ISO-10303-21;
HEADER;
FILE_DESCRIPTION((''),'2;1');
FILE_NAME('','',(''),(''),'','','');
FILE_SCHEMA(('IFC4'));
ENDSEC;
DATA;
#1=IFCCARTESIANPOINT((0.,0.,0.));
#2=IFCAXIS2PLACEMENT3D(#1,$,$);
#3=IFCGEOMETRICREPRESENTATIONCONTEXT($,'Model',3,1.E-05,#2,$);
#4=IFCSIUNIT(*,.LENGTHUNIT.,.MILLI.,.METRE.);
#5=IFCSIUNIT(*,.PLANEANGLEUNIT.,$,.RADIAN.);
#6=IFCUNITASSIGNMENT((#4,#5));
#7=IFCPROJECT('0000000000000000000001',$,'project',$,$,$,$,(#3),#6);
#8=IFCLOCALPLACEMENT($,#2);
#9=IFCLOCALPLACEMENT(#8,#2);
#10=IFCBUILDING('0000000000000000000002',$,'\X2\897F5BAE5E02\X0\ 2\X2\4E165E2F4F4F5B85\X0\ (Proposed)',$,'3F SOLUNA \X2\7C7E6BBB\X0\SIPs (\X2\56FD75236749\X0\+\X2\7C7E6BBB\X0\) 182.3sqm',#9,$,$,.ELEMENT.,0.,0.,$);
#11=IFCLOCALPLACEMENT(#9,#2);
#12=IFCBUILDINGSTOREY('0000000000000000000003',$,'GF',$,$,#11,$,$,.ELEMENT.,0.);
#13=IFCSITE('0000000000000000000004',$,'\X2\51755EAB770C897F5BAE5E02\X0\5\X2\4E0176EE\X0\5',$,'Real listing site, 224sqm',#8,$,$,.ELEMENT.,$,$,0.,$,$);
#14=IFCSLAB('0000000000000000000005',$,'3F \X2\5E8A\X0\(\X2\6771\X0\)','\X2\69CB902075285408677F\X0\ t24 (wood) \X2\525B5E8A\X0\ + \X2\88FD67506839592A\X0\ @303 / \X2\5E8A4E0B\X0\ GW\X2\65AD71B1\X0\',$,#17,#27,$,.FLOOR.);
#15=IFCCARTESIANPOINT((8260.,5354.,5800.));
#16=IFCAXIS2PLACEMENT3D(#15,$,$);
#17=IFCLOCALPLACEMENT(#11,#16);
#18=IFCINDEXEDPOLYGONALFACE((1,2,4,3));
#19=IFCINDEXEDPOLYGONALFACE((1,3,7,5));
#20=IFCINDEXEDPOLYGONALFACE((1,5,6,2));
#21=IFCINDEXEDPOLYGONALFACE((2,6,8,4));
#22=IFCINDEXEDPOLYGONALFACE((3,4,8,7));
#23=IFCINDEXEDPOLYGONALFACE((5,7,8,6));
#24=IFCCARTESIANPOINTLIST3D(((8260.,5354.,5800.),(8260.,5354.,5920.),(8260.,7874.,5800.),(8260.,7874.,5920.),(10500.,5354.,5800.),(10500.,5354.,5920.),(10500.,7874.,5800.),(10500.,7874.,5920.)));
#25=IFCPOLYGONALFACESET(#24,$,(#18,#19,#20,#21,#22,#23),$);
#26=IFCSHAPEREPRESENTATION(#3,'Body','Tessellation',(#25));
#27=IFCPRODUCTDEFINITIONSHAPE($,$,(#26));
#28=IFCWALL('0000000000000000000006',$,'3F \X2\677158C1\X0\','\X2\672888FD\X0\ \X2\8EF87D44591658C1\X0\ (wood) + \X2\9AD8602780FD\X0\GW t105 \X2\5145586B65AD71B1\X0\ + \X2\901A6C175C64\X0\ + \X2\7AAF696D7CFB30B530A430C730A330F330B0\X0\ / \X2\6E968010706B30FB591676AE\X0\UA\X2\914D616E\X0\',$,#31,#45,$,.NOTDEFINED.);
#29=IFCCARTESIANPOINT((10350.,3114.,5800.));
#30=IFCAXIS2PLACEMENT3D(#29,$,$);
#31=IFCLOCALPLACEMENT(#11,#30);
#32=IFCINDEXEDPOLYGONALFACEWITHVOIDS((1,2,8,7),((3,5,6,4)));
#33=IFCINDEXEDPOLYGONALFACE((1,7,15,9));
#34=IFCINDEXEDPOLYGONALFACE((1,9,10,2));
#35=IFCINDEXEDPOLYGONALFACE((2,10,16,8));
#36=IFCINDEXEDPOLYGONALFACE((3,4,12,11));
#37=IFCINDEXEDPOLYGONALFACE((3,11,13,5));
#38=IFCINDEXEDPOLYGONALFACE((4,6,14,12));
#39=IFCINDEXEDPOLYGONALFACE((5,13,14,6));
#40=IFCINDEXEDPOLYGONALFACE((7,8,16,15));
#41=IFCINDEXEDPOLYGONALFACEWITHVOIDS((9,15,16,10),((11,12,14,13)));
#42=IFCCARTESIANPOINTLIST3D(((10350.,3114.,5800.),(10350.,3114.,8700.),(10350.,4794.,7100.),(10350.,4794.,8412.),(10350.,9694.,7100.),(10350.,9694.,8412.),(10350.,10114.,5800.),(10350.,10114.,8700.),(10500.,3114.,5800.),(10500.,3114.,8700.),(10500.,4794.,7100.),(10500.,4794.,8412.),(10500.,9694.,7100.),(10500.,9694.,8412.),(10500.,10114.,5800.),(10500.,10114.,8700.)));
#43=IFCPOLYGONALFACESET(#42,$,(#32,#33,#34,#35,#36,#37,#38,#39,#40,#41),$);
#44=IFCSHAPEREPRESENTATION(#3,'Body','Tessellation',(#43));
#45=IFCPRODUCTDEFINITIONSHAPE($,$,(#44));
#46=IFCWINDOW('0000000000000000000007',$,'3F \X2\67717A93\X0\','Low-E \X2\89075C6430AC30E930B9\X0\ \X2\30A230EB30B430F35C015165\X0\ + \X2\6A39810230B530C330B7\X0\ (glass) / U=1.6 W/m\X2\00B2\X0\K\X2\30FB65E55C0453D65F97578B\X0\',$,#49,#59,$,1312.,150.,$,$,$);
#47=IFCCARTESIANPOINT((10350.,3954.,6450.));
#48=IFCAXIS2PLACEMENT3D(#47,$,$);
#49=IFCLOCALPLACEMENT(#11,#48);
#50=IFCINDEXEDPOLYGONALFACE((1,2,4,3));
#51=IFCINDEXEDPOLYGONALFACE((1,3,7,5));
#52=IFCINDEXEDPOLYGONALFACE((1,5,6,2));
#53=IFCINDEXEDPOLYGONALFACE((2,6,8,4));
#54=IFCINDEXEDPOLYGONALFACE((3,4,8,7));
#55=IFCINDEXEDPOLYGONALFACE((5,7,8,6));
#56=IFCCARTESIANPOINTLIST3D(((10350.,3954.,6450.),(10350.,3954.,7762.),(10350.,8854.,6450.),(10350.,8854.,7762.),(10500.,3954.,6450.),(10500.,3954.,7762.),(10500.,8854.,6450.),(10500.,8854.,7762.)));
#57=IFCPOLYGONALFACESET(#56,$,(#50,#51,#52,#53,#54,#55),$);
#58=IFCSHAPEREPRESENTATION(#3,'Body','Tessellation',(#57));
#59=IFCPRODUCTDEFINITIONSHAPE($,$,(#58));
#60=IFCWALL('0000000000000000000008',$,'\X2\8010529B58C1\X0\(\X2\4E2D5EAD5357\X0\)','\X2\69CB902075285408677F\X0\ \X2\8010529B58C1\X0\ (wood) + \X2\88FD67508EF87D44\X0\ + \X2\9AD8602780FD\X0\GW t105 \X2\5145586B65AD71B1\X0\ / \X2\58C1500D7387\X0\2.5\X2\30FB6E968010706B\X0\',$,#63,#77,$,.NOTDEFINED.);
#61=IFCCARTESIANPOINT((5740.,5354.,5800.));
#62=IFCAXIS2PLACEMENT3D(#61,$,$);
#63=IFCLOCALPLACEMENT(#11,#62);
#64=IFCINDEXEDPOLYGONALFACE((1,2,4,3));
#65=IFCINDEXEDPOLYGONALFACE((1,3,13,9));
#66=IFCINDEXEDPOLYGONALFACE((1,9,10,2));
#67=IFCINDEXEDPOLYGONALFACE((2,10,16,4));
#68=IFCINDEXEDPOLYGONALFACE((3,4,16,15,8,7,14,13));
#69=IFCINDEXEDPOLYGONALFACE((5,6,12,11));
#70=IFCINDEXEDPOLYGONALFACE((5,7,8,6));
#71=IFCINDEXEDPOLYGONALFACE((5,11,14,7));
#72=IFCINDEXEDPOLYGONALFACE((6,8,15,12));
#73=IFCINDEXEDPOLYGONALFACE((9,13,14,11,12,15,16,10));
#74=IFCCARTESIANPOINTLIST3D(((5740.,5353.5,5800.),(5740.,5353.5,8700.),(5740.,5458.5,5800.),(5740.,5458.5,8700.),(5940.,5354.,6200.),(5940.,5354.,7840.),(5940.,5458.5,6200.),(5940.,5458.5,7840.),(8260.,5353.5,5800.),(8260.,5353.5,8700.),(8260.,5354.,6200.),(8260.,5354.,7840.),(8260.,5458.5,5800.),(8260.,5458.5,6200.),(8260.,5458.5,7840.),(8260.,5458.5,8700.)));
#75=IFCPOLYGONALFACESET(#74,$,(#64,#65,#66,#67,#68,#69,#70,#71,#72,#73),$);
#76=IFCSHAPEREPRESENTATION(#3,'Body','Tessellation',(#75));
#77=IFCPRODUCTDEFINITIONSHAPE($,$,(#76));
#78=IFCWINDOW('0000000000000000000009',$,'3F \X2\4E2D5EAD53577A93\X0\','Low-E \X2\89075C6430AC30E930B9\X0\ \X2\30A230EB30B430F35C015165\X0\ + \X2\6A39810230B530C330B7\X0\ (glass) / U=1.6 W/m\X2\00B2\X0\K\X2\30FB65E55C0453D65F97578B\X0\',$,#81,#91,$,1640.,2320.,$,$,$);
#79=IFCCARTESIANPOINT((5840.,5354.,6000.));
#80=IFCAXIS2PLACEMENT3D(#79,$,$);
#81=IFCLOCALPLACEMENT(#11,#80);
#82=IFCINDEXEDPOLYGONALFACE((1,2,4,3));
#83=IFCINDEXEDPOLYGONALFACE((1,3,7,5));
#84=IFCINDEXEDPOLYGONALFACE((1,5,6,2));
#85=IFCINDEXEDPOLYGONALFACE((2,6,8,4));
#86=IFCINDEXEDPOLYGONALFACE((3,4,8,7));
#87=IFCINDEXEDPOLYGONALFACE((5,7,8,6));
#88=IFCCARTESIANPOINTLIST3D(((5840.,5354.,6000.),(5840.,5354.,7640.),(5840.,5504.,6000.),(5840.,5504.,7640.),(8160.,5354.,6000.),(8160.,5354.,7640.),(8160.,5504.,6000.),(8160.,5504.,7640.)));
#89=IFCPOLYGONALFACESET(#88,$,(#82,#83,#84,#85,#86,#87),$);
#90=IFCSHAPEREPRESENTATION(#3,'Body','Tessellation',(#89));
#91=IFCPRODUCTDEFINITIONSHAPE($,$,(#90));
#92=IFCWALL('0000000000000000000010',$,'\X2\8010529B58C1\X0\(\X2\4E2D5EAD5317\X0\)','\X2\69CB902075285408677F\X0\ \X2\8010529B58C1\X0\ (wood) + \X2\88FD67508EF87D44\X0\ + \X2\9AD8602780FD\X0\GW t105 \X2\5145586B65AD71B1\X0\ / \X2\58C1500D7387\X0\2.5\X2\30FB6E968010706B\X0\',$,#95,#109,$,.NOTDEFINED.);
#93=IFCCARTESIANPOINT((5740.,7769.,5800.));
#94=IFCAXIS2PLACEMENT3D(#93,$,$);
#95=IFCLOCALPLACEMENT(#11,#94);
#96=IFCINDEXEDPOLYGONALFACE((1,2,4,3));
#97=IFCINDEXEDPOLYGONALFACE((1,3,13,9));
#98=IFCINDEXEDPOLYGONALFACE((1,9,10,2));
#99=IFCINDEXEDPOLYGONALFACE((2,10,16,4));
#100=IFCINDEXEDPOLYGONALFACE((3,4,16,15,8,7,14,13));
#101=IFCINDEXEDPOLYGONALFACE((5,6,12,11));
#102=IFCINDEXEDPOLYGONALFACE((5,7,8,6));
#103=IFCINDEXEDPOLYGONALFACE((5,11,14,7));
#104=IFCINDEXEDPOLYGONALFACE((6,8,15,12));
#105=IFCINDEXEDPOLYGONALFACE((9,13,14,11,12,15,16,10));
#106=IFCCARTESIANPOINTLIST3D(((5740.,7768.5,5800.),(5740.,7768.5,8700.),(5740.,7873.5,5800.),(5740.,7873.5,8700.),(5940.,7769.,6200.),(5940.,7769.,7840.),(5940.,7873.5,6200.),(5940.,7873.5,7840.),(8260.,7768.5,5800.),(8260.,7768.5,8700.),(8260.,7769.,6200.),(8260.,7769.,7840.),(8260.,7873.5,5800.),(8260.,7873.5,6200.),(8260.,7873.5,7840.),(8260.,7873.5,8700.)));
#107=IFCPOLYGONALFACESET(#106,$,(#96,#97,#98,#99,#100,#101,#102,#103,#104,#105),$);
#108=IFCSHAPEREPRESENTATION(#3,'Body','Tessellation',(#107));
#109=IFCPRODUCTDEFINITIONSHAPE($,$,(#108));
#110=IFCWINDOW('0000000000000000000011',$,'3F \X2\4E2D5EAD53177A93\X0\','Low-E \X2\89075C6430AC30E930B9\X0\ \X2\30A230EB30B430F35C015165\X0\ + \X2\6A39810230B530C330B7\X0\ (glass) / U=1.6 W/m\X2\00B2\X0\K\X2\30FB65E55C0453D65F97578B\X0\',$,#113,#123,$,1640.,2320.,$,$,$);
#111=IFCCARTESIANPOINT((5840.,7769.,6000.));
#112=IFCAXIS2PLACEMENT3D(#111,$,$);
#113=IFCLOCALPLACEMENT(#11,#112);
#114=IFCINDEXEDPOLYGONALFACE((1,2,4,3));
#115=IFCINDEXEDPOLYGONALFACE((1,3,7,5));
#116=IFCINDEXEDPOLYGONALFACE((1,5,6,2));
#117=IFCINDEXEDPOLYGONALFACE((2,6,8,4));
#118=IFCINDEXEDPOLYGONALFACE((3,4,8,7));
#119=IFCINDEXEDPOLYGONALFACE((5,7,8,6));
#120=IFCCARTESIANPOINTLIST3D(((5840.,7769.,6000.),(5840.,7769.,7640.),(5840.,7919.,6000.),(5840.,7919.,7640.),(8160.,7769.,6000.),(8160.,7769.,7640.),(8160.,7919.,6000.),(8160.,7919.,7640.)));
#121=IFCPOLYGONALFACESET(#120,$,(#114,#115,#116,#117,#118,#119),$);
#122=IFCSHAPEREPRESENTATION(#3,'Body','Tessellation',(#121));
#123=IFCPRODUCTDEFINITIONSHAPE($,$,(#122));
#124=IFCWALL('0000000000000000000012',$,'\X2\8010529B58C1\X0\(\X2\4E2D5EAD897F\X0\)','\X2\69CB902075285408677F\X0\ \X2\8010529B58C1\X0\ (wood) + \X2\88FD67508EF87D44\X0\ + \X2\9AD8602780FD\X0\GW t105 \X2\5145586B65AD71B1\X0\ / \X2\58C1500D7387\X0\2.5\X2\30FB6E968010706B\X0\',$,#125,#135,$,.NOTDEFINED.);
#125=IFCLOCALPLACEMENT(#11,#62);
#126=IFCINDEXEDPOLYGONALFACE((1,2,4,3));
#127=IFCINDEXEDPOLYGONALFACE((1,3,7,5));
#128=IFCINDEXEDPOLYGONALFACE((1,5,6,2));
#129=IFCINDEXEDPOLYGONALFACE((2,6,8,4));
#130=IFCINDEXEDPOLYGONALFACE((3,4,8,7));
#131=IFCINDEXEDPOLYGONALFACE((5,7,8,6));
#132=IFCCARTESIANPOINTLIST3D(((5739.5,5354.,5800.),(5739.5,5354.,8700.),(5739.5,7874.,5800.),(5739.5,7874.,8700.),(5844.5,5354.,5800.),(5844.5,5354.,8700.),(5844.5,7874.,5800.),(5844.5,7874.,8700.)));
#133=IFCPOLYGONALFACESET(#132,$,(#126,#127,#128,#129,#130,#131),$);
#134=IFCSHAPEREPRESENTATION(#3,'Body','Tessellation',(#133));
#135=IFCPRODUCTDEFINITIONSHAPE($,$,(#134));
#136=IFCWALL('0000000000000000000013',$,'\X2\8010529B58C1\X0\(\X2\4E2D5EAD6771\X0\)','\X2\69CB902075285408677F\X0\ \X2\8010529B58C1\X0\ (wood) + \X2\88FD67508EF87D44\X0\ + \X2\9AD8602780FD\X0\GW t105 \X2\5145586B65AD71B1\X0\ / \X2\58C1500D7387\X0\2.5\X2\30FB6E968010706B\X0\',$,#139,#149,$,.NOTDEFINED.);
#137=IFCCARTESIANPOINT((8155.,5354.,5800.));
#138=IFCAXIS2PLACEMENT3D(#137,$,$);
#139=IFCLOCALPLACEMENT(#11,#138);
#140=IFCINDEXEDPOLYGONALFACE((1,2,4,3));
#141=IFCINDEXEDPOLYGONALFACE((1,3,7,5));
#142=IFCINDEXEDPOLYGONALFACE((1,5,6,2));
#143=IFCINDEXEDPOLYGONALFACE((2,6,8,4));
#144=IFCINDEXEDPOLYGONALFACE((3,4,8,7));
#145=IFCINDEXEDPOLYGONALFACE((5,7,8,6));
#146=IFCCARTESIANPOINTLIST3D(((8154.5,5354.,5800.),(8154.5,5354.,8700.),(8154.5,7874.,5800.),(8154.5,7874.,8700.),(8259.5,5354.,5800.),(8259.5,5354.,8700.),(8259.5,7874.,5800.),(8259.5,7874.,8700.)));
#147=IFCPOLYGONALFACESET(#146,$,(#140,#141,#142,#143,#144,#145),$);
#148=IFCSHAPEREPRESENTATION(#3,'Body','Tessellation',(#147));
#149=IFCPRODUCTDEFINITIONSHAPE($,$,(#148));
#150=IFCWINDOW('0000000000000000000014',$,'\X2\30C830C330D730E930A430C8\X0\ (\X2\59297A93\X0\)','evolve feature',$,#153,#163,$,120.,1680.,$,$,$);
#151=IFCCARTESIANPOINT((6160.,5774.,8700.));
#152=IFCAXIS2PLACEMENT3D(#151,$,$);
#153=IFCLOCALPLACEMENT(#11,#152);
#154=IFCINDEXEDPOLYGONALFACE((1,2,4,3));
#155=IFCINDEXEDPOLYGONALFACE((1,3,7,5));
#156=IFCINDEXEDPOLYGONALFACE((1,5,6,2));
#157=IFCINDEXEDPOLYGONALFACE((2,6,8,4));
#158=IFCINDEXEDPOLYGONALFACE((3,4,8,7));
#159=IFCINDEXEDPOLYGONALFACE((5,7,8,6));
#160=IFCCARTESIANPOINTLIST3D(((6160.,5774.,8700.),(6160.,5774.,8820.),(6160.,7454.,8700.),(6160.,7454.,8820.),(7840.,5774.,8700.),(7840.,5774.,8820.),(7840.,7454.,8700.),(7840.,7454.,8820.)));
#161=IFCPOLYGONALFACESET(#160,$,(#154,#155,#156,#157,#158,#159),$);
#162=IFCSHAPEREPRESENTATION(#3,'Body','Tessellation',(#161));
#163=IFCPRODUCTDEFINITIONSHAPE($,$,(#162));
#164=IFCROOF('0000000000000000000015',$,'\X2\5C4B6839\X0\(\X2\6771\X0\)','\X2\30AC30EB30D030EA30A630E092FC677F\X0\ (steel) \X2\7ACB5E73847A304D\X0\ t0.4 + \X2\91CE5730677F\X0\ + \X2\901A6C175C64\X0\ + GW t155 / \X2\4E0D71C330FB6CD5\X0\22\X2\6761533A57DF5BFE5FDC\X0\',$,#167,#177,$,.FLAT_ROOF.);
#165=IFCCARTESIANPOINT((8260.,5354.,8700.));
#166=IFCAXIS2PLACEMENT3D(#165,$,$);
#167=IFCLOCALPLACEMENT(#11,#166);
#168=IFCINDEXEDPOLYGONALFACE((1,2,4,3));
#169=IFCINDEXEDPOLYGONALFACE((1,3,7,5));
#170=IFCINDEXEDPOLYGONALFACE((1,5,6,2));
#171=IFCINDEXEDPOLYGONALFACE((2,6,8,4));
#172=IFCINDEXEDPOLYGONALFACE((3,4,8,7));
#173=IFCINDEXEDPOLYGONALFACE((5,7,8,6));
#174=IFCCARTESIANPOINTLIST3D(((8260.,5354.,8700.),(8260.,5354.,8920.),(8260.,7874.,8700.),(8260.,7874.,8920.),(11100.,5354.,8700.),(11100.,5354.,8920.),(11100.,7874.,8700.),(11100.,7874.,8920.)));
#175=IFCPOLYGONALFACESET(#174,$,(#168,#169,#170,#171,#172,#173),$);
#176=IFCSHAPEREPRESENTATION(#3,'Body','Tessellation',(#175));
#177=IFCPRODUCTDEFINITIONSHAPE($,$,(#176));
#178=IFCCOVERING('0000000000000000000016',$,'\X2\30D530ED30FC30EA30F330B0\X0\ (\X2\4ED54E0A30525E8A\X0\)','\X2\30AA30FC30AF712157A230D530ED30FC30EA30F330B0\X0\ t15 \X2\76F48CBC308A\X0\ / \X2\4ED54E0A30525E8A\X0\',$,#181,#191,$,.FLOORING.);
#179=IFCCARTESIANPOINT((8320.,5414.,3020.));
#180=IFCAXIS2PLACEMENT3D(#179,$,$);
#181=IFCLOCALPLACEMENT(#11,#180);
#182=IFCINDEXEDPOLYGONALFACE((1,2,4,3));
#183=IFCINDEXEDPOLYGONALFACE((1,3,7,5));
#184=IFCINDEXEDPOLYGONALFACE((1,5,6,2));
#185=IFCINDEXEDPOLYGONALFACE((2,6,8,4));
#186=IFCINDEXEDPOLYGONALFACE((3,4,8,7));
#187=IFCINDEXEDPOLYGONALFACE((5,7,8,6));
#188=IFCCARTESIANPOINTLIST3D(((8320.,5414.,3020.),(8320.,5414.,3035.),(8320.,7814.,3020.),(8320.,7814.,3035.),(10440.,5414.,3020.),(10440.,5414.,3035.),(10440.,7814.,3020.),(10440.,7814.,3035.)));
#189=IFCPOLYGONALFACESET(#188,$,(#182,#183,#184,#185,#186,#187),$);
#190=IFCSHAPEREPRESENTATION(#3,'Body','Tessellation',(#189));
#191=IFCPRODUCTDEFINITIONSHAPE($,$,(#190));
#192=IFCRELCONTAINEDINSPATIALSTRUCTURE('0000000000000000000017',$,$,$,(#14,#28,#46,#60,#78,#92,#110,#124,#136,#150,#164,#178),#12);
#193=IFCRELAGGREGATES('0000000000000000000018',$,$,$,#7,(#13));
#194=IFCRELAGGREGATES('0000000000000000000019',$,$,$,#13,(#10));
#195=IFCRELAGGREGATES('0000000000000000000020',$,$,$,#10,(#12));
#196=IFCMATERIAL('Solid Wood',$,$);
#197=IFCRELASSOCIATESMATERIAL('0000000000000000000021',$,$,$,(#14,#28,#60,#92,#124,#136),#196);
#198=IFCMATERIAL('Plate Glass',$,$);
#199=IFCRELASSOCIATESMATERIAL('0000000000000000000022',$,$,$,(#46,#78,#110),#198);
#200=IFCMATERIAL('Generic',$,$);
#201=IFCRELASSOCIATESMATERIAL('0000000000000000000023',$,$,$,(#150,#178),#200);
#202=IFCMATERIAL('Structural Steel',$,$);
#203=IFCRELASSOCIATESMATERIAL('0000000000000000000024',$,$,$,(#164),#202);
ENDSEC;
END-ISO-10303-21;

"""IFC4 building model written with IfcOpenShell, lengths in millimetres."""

from ifc_helpers import new_model, si_unit, frame, frame_2d, origin, place, context, project, spatial, rectangle, extrude, material, element, fill, save


model = new_model("IFC4")

# Units and contexts
model_context = context("Model", 3, precision=1e-05, world=origin())
ifc_project = project(units=[si_unit("LENGTHUNIT", "METRE", prefix="MILLI"), si_unit("PLANEANGLEUNIT", "RADIAN")], contexts=[model_context])

# Site, building, storey
site_placement = place(None, origin())
site = spatial("IfcSite", under=ifc_project, at=site_placement, Name="兵庫県西宮市5丁目5", ObjectType="Real listing site, 224sqm", CompositionType="ELEMENT", RefElevation=0.0)
building_placement = place(site_placement, origin())
building = spatial("IfcBuilding", under=site, at=building_placement, Name="西宮市 2世帯住宅 (Proposed)", ObjectType="3F SOLUNA 籾殻SIPs (国産杉+籾殻) 182.3sqm", CompositionType="ELEMENT", ElevationOfRefHeight=0.0, ElevationOfTerrain=0.0)
storey_placement = place(building_placement, origin())
storey = spatial("IfcBuildingStorey", under=building, at=storey_placement, Name="GF", CompositionType="ELEMENT", Elevation=0.0)

# Slab
ifc_material_1 = material(Name="Solid Wood")
slab_placement = place(storey_placement, frame((8260.0, 5354.0, 5800.0)))
element("IfcSlab", 1, at=slab_placement, inside=storey, material=ifc_material_1, Name="3F 床(東)", Description="構造用合板 t24 (wood) 剛床 + 製材根太 @303 / 床下 GW断熱", PredefinedType="FLOOR", context=model_context, shape_type="SweptSolid", body=[
    extrude(rectangle(XDim=2240.0, YDim=2520.0, at=frame_2d((1120.0, 1260.0))), frame((8260.0, 5354.0, 5800.0)), (0.0, 0.0, 1.0), 120.0),
])

# Walls, openings, windows
wall_1_placement = place(storey_placement, frame((10350.0, 3114.0, 5800.0)))
wall_1 = element("IfcWall", 2, at=wall_1_placement, inside=storey, material=ifc_material_1, Name="3F 東壁", Description="木製 軸組外壁 (wood) + 高性能GW t105 充填断熱 + 通気層 + 窯業系サイディング / 準耐火・外皮UA配慮", PredefinedType="NOTDEFINED", context=model_context, shape_type="SweptSolid", body=[
    extrude(rectangle(XDim=150.0, YDim=7000.0, at=frame_2d((75.0, 3500.0))), frame((10350.0, 3114.0, 5800.0)), (0.0, 0.0, 1.0), 2900.0),
])
opening_1_placement = place(storey_placement, frame((10350.0, 3954.0, 6450.0)))
opening_1 = element("IfcOpeningElement", 3, at=opening_1_placement, cuts=wall_1, PredefinedType="NOTDEFINED", context=model_context, shape_type="SweptSolid", body=[
    extrude(rectangle(XDim=150.0, YDim=4900.0, at=frame_2d((75.0, 2450.0))), frame((10350.0, 3954.0, 6450.0)), (0.0, 0.0, 1.0), 1312.0),
])
ifc_material_2 = material(Name="Plate Glass")
window_1_placement = place(storey_placement, frame((10350.0, 3954.0, 6450.0)))
window_1 = element("IfcWindow", 4, at=window_1_placement, inside=storey, material=ifc_material_2, Name="3F 東窓", Description="Low-E 複層ガラス アルゴン封入 + 樹脂サッシ (glass) / U=1.6 W/m²K・日射取得型", OverallHeight=1312.0, OverallWidth=150.0, context=model_context, shape_type="SweptSolid", body=[
    extrude(rectangle(XDim=150.0, YDim=4900.0, at=frame_2d((75.0, 2450.0))), frame((10350.0, 3954.0, 6450.0)), (0.0, 0.0, 1.0), 1312.0),
])
fill(opening_1, window_1)
wall_2_placement = place(storey_placement, frame((5740.0, 5354.0, 5800.0)))
wall_2 = element("IfcWall", 5, at=wall_2_placement, inside=storey, material=ifc_material_1, Name="耐力壁(中庭南)", Description="構造用合板 耐力壁 (wood) + 製材軸組 + 高性能GW t105 充填断熱 / 壁倍率2.5・準耐火", PredefinedType="NOTDEFINED", context=model_context, shape_type="SweptSolid", body=[
    extrude(rectangle(XDim=2520.0, YDim=105.0, at=frame_2d((1260.0, 52.0))), frame((5740.0, 5354.0, 5800.0)), (0.0, 0.0, 1.0), 2900.0),
])
opening_2_placement = place(storey_placement, frame((5840.0, 5354.0, 6000.0)))
opening_2 = element("IfcOpeningElement", 6, at=opening_2_placement, cuts=wall_2, PredefinedType="NOTDEFINED", context=model_context, shape_type="SweptSolid", body=[
    extrude(rectangle(XDim=2320.0, YDim=150.0, at=frame_2d((1160.0, 75.0))), frame((5840.0, 5354.0, 6000.0)), (0.0, 0.0, 1.0), 1640.0),
])
window_2_placement = place(storey_placement, frame((5840.0, 5354.0, 6000.0)))
window_2 = element("IfcWindow", 7, at=window_2_placement, inside=storey, material=ifc_material_2, Name="3F 中庭南窓", Description="Low-E 複層ガラス アルゴン封入 + 樹脂サッシ (glass) / U=1.6 W/m²K・日射取得型", OverallHeight=1640.0, OverallWidth=2320.0, context=model_context, shape_type="SweptSolid", body=[
    extrude(rectangle(XDim=2320.0, YDim=150.0, at=frame_2d((1160.0, 75.0))), frame((5840.0, 5354.0, 6000.0)), (0.0, 0.0, 1.0), 1640.0),
])
fill(opening_2, window_2)
wall_3_placement = place(storey_placement, frame((5740.0, 7769.0, 5800.0)))
wall_3 = element("IfcWall", 8, at=wall_3_placement, inside=storey, material=ifc_material_1, Name="耐力壁(中庭北)", Description="構造用合板 耐力壁 (wood) + 製材軸組 + 高性能GW t105 充填断熱 / 壁倍率2.5・準耐火", PredefinedType="NOTDEFINED", context=model_context, shape_type="SweptSolid", body=[
    extrude(rectangle(XDim=2520.0, YDim=105.0, at=frame_2d((1260.0, 52.0))), frame((5740.0, 7769.0, 5800.0)), (0.0, 0.0, 1.0), 2900.0),
])
opening_3_placement = place(storey_placement, frame((5840.0, 7769.0, 6000.0)))
opening_3 = element("IfcOpeningElement", 9, at=opening_3_placement, cuts=wall_3, PredefinedType="NOTDEFINED", context=model_context, shape_type="SweptSolid", body=[
    extrude(rectangle(XDim=2320.0, YDim=150.0, at=frame_2d((1160.0, 75.0))), frame((5840.0, 7769.0, 6000.0)), (0.0, 0.0, 1.0), 1640.0),
])
window_3_placement = place(storey_placement, frame((5840.0, 7769.0, 6000.0)))
window_3 = element("IfcWindow", 10, at=window_3_placement, inside=storey, material=ifc_material_2, Name="3F 中庭北窓", Description="Low-E 複層ガラス アルゴン封入 + 樹脂サッシ (glass) / U=1.6 W/m²K・日射取得型", OverallHeight=1640.0, OverallWidth=2320.0, context=model_context, shape_type="SweptSolid", body=[
    extrude(rectangle(XDim=2320.0, YDim=150.0, at=frame_2d((1160.0, 75.0))), frame((5840.0, 7769.0, 6000.0)), (0.0, 0.0, 1.0), 1640.0),
])
fill(opening_3, window_3)

# Walls
wall_4_placement = place(storey_placement, frame((5740.0, 5354.0, 5800.0)))
element("IfcWall", 11, at=wall_4_placement, inside=storey, material=ifc_material_1, Name="耐力壁(中庭西)", Description="構造用合板 耐力壁 (wood) + 製材軸組 + 高性能GW t105 充填断熱 / 壁倍率2.5・準耐火", PredefinedType="NOTDEFINED", context=model_context, shape_type="SweptSolid", body=[
    extrude(rectangle(XDim=105.0, YDim=2520.0, at=frame_2d((52.0, 1260.0))), frame((5740.0, 5354.0, 5800.0)), (0.0, 0.0, 1.0), 2900.0),
])
wall_5_placement = place(storey_placement, frame((8155.0, 5354.0, 5800.0)))
element("IfcWall", 12, at=wall_5_placement, inside=storey, material=ifc_material_1, Name="耐力壁(中庭東)", Description="構造用合板 耐力壁 (wood) + 製材軸組 + 高性能GW t105 充填断熱 / 壁倍率2.5・準耐火", PredefinedType="NOTDEFINED", context=model_context, shape_type="SweptSolid", body=[
    extrude(rectangle(XDim=105.0, YDim=2520.0, at=frame_2d((52.0, 1260.0))), frame((8155.0, 5354.0, 5800.0)), (0.0, 0.0, 1.0), 2900.0),
])

# Window
ifc_material_3 = material(Name="Generic")
window_4_placement = place(storey_placement, frame((6160.0, 5774.0, 8700.0)))
element("IfcWindow", 13, at=window_4_placement, inside=storey, material=ifc_material_3, Name="トップライト (天窓)", Description="evolve feature", OverallHeight=120.0, OverallWidth=1680.0, context=model_context, shape_type="SweptSolid", body=[
    extrude(rectangle(XDim=1680.0, YDim=1680.0, at=frame_2d((840.0, 840.0))), frame((6160.0, 5774.0, 8700.0)), (0.0, 0.0, 1.0), 120.0),
])

# Roof
ifc_material_4 = material(Name="Structural Steel")
for number, where, name in (
    (14, (8260.0, 5354.0, 8700.0), "屋根(東)"),
):
    element("IfcRoof", number, at=place(storey_placement, frame(where)), inside=storey, material=ifc_material_4, Name=name, Description="ガルバリウム鋼板 (steel) 立平葺き t0.4 + 野地板 + 通気層 + GW t155 / 不燃・法22条区域対応", PredefinedType="FLAT_ROOF", context=model_context, shape_type="SweptSolid", body=[
        extrude(rectangle(XDim=2840.0, YDim=2520.0, at=frame_2d((1420.0, 1260.0))), frame((8260.0, 5354.0, 8700.0)), (0.0, 0.0, 1.0), 220.0),
    ])

# Covering
covering_1_placement = place(storey_placement, frame((8320.0, 5414.0, 3020.0)))
element("IfcCovering", 15, at=covering_1_placement, inside=storey, material=ifc_material_3, Name="フローリング (仕上げ床)", Description="オーク無垢フローリング t15 直貼り / 仕上げ床", PredefinedType="FLOORING", context=model_context, shape_type="SweptSolid", body=[
    extrude(rectangle(XDim=2120.0, YDim=2400.0, at=frame_2d((1060.0, 1200.0))), frame((8320.0, 5414.0, 3020.0)), (0.0, 0.0, 1.0), 15.0),
])

save(model, "model.ifc")
